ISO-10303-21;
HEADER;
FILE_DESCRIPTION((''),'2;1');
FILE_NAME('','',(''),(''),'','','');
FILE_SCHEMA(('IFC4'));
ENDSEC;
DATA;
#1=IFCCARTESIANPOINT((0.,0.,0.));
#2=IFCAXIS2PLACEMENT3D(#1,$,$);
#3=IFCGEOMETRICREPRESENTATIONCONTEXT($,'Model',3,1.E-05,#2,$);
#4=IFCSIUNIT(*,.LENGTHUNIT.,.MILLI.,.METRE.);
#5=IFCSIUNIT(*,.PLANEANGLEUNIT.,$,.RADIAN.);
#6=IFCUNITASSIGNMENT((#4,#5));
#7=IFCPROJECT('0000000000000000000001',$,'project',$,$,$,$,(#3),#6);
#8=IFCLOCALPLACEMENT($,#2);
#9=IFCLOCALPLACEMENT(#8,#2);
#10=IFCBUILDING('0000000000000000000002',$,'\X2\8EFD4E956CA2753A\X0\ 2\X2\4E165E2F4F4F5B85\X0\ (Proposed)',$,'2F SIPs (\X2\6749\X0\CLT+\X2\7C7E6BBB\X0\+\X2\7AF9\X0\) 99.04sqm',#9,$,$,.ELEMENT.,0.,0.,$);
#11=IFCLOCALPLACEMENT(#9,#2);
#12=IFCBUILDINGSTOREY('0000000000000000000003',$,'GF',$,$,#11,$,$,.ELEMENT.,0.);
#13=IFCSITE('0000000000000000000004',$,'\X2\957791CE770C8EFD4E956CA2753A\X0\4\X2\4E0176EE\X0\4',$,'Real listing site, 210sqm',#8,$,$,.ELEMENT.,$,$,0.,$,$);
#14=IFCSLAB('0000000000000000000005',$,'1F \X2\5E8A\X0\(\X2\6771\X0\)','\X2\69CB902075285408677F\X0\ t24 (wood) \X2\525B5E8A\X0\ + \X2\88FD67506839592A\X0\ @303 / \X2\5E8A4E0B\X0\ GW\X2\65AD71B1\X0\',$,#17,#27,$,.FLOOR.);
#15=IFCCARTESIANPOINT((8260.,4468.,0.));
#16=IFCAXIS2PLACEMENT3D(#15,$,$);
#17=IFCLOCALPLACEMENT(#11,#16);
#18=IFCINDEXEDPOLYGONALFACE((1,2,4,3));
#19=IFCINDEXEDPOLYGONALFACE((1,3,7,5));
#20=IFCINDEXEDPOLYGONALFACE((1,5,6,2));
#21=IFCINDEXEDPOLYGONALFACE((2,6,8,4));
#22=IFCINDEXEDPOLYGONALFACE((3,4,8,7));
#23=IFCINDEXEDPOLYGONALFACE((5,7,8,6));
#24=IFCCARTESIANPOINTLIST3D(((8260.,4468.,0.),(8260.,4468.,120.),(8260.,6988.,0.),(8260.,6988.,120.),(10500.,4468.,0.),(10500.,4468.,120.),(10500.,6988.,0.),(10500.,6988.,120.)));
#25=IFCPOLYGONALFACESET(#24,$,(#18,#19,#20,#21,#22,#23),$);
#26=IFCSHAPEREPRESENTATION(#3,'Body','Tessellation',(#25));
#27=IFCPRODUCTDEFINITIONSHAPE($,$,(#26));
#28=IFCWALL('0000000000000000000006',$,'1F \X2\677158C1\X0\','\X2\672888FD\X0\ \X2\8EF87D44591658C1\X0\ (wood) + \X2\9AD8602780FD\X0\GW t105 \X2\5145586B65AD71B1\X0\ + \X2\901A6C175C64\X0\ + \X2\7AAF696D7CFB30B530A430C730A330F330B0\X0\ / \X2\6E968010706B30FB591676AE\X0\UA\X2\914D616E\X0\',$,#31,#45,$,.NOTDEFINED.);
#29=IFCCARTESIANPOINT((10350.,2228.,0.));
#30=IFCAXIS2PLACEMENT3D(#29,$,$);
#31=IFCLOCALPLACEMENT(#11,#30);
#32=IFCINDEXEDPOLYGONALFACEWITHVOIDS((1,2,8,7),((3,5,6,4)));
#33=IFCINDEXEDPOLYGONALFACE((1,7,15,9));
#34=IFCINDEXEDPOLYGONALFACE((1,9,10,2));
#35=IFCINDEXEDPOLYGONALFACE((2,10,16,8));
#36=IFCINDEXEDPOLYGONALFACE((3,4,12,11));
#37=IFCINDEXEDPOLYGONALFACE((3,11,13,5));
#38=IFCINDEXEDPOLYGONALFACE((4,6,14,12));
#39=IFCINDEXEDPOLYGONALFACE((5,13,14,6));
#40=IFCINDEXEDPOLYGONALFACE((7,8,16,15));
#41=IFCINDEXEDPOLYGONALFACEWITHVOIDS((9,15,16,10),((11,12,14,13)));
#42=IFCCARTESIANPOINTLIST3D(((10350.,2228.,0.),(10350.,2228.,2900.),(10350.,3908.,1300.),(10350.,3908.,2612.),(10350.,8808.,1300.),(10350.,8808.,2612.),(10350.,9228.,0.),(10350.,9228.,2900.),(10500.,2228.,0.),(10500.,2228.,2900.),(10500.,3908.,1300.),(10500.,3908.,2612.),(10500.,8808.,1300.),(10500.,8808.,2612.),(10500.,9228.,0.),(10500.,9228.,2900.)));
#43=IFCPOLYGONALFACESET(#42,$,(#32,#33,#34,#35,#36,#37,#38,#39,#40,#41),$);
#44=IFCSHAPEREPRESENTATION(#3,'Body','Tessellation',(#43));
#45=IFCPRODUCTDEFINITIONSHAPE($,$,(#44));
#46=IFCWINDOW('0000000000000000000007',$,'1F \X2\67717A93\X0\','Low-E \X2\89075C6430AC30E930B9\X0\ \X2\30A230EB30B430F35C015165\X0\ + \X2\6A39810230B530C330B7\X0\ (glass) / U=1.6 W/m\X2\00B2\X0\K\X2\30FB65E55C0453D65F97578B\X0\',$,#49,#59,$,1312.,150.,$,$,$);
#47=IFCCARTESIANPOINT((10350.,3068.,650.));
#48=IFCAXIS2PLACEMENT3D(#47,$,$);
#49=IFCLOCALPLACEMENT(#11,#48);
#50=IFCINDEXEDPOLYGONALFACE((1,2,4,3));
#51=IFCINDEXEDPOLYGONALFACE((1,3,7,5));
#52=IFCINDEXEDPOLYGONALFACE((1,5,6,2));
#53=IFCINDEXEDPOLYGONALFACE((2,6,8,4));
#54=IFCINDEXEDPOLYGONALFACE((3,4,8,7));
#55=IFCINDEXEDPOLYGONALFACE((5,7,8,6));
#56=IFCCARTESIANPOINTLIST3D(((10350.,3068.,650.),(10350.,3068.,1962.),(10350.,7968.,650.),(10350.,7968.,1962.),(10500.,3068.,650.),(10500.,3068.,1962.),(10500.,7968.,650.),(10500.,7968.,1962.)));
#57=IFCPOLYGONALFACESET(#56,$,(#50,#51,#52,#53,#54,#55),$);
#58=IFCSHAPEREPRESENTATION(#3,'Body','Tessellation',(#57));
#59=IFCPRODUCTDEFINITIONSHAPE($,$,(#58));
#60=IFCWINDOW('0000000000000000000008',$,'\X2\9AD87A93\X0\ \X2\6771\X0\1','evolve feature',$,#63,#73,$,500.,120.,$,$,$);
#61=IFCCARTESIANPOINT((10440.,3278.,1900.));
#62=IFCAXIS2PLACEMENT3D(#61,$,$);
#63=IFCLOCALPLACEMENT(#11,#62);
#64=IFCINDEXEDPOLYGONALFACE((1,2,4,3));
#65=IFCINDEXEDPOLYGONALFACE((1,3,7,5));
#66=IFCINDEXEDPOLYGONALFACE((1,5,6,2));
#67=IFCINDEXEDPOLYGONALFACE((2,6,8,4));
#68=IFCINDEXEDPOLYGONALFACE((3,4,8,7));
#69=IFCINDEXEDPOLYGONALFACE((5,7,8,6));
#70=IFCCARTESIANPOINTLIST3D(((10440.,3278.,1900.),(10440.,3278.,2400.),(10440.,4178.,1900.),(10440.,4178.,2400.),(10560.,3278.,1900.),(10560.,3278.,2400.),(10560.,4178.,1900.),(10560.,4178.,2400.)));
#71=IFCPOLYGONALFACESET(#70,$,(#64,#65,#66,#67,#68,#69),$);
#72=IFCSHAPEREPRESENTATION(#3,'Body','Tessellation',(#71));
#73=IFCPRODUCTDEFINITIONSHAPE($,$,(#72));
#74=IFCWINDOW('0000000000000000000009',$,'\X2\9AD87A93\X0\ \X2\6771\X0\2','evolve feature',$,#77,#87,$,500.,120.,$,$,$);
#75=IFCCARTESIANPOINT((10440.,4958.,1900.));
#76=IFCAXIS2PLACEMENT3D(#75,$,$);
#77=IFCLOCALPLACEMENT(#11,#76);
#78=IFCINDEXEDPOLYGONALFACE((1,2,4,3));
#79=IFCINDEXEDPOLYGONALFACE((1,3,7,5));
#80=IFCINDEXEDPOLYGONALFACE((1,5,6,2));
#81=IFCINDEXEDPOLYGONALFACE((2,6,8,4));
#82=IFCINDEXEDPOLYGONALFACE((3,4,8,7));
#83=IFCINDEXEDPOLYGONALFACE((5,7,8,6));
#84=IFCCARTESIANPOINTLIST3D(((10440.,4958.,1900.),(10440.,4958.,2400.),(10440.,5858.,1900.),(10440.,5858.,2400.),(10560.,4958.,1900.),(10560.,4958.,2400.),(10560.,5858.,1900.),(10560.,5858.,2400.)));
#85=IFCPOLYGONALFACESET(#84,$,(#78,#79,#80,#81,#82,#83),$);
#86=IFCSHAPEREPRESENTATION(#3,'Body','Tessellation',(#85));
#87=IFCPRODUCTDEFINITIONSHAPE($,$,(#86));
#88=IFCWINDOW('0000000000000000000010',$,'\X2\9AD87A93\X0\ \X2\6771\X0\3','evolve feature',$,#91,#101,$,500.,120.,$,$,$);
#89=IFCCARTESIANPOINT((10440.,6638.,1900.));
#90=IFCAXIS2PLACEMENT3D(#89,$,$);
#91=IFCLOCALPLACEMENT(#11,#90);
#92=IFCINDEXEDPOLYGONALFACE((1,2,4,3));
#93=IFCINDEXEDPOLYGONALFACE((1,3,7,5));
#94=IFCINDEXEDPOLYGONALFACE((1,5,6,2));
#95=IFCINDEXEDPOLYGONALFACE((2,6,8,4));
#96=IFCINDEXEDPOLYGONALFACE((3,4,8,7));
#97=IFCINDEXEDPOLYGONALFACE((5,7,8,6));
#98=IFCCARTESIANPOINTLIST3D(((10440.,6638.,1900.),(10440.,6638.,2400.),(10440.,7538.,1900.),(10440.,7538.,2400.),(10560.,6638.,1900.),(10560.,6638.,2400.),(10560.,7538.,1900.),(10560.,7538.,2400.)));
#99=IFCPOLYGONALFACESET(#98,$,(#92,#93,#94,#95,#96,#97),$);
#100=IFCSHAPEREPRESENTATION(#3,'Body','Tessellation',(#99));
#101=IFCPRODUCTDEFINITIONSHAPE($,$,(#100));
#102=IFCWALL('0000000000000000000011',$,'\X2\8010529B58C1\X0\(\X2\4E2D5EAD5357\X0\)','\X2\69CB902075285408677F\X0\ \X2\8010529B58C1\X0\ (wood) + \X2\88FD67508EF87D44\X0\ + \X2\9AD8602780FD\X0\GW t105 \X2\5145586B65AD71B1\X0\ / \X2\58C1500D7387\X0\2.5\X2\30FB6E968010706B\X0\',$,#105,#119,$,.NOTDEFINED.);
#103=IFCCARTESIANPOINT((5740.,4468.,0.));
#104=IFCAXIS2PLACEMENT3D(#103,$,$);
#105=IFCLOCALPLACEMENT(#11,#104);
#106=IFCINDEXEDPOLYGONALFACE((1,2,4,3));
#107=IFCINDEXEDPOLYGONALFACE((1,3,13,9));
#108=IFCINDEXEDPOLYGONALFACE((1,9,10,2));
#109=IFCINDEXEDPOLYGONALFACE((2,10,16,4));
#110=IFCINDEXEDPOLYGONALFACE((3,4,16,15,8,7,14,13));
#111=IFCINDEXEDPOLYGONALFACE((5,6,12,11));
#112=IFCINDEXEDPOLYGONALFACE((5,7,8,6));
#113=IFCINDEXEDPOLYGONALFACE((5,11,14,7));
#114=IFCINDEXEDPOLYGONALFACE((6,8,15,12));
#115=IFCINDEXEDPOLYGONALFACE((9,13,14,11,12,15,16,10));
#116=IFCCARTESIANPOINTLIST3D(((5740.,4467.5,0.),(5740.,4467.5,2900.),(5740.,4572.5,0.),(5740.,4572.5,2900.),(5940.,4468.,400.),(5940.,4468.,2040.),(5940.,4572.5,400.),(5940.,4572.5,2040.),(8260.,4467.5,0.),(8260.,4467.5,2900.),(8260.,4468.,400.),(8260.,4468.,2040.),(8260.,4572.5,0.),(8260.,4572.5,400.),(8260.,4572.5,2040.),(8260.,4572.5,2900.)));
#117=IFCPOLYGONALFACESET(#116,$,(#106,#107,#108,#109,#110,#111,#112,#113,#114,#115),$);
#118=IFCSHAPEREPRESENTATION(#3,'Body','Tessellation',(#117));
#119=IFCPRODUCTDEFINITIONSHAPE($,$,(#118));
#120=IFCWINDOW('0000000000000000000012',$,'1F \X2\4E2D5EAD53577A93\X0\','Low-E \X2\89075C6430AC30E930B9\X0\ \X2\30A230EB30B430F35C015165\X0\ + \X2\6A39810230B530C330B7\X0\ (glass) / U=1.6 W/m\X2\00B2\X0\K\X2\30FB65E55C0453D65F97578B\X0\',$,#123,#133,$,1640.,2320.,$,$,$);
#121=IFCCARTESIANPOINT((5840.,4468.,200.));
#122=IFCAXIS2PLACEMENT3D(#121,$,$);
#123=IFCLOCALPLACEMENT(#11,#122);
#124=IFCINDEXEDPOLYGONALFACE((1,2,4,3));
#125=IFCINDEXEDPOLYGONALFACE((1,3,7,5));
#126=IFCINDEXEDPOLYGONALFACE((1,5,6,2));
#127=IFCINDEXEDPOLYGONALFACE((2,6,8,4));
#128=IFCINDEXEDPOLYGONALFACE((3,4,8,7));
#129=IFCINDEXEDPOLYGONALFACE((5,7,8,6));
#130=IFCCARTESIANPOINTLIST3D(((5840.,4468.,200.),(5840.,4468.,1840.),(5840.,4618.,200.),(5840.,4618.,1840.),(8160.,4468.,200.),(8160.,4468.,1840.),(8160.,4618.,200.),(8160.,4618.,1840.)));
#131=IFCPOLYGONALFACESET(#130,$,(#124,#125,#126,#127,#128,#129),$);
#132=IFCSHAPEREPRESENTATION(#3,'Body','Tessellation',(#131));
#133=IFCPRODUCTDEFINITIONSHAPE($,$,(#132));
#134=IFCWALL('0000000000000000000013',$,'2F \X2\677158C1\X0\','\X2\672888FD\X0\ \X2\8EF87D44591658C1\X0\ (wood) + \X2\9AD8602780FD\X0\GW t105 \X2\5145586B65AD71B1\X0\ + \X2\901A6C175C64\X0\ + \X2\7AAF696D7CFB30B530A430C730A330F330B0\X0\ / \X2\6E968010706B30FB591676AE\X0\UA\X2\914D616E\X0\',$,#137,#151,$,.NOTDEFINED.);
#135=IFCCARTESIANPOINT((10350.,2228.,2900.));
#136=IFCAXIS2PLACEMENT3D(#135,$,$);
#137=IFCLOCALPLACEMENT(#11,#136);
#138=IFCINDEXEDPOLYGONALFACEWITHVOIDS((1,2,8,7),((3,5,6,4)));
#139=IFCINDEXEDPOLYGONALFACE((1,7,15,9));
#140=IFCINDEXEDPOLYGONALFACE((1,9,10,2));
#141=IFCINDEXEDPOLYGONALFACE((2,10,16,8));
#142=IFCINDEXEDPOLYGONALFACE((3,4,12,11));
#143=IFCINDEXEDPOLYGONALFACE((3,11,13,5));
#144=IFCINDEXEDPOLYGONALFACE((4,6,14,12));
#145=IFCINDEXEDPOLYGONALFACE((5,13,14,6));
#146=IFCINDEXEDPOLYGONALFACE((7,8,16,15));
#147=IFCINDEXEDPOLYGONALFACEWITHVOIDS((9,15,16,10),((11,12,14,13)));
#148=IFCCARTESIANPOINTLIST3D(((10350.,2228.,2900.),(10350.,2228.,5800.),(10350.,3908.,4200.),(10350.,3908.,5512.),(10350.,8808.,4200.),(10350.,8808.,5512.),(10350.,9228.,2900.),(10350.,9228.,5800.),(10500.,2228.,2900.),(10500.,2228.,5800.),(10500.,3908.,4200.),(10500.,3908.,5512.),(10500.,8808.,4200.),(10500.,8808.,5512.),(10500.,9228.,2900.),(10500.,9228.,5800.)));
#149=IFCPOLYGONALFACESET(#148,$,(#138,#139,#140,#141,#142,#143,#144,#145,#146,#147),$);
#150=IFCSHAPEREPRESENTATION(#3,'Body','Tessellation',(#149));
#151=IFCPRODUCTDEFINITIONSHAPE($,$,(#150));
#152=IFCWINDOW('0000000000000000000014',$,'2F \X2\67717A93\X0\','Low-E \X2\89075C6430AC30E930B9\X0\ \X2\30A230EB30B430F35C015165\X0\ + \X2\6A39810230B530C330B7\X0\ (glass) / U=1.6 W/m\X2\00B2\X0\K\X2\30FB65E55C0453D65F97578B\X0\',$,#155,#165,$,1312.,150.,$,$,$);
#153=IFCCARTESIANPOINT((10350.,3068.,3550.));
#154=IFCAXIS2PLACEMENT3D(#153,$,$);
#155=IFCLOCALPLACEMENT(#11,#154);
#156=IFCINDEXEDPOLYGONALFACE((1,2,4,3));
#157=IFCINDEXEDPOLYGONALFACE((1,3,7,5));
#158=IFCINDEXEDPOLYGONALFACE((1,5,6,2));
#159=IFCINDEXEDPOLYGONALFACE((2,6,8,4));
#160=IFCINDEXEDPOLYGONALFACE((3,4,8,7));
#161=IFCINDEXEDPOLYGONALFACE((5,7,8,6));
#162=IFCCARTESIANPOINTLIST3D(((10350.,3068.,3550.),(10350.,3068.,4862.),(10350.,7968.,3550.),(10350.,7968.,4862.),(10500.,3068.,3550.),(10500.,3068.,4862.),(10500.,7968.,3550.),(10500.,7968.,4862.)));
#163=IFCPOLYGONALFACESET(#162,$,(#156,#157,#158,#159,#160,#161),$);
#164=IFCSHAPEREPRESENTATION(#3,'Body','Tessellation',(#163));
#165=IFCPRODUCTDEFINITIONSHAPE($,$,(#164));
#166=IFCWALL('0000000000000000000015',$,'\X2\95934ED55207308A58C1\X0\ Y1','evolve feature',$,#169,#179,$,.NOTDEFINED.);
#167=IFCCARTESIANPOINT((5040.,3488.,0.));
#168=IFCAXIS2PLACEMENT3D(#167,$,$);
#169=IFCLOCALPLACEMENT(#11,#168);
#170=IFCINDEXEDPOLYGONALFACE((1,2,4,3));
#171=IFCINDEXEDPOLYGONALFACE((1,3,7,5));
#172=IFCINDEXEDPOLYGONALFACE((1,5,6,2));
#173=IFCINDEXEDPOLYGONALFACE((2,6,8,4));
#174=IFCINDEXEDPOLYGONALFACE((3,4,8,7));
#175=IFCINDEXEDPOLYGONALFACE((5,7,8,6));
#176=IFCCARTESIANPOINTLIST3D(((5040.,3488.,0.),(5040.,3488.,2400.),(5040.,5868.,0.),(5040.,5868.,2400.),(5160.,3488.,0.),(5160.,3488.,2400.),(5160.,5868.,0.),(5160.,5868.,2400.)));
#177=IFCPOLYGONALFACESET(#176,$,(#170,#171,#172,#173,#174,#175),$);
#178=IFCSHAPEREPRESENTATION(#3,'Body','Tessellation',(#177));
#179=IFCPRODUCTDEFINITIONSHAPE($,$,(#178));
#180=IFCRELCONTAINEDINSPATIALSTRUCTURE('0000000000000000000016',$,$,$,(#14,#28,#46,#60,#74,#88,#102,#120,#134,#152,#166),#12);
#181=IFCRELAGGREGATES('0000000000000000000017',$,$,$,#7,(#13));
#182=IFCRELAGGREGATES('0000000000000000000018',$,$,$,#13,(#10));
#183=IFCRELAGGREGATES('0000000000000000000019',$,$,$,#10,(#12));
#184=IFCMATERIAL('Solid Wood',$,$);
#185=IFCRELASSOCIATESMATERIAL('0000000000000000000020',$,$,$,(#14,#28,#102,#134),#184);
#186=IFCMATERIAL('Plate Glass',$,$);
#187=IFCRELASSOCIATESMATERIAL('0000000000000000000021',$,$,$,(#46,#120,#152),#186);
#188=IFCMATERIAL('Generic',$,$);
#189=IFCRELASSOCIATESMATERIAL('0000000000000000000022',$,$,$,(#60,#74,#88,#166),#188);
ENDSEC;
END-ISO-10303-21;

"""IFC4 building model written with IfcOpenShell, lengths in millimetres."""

from ifc_helpers import new_model, si_unit, frame, frame_2d, origin, place, context, project, spatial, rectangle, extrude, material, element, fill, save


model = new_model("IFC4")

# Units and contexts
model_context = context("Model", 3, precision=1e-05, world=origin())
ifc_project = project(units=[si_unit("LENGTHUNIT", "METRE", prefix="MILLI"), si_unit("PLANEANGLEUNIT", "RADIAN")], contexts=[model_context])

# Site, building, storey
site_placement = place(None, origin())
site = spatial("IfcSite", under=ifc_project, at=site_placement, Name="長野県軽井沢町4丁目4", ObjectType="Real listing site, 210sqm", CompositionType="ELEMENT", RefElevation=0.0)
building_placement = place(site_placement, origin())
building = spatial("IfcBuilding", under=site, at=building_placement, Name="軽井沢町 2世帯住宅 (Proposed)", ObjectType="2F SIPs (杉CLT+籾殻+竹) 99.04sqm", CompositionType="ELEMENT", ElevationOfRefHeight=0.0, ElevationOfTerrain=0.0)
storey_placement = place(building_placement, origin())
storey = spatial("IfcBuildingStorey", under=building, at=storey_placement, Name="GF", CompositionType="ELEMENT", Elevation=0.0)

# Slab
ifc_material_1 = material(Name="Solid Wood")
slab_placement = place(storey_placement, frame((8260.0, 4468.0, 0.0)))
element("IfcSlab", 1, at=slab_placement, inside=storey, material=ifc_material_1, Name="1F 床(東)", Description="構造用合板 t24 (wood) 剛床 + 製材根太 @303 / 床下 GW断熱", PredefinedType="FLOOR", context=model_context, shape_type="SweptSolid", body=[
    extrude(rectangle(XDim=2240.0, YDim=2520.0, at=frame_2d((1120.0, 1260.0))), frame((8260.0, 4468.0, 0.0)), (0.0, 0.0, 1.0), 120.0),
])

# Wall, openings, windows
wall_1_placement = place(storey_placement, frame((10350.0, 2228.0, 0.0)))
wall_1 = element("IfcWall", 2, at=wall_1_placement, inside=storey, material=ifc_material_1, Name="1F 東壁", Description="木製 軸組外壁 (wood) + 高性能GW t105 充填断熱 + 通気層 + 窯業系サイディング / 準耐火・外皮UA配慮", PredefinedType="NOTDEFINED", context=model_context, shape_type="SweptSolid", body=[
    extrude(rectangle(XDim=150.0, YDim=7000.0, at=frame_2d((75.0, 3500.0))), frame((10350.0, 2228.0, 0.0)), (0.0, 0.0, 1.0), 2900.0),
])
opening_1_placement = place(storey_placement, frame((10350.0, 3068.0, 650.0)))
opening_1 = element("IfcOpeningElement", 3, at=opening_1_placement, cuts=wall_1, PredefinedType="NOTDEFINED", context=model_context, shape_type="SweptSolid", body=[
    extrude(rectangle(XDim=150.0, YDim=4900.0, at=frame_2d((75.0, 2450.0))), frame((10350.0, 3068.0, 650.0)), (0.0, 0.0, 1.0), 1312.0),
])
opening_2_placement = place(storey_placement, frame((10440.0, 3278.0, 1900.0)))
opening_2 = element("IfcOpeningElement", 4, at=opening_2_placement, cuts=wall_1, PredefinedType="NOTDEFINED", context=model_context, shape_type="SweptSolid", body=[
    extrude(rectangle(XDim=120.0, YDim=900.0, at=frame_2d((60.0, 450.0))), frame((10440.0, 3278.0, 1900.0)), (0.0, 0.0, 1.0), 500.0),
])
opening_3_placement = place(storey_placement, frame((10440.0, 4958.0, 1900.0)))
opening_3 = element("IfcOpeningElement", 5, at=opening_3_placement, cuts=wall_1, PredefinedType="NOTDEFINED", context=model_context, shape_type="SweptSolid", body=[
    extrude(rectangle(XDim=120.0, YDim=900.0, at=frame_2d((60.0, 450.0))), frame((10440.0, 4958.0, 1900.0)), (0.0, 0.0, 1.0), 500.0),
])
opening_4_placement = place(storey_placement, frame((10440.0, 6638.0, 1900.0)))
opening_4 = element("IfcOpeningElement", 6, at=opening_4_placement, cuts=wall_1, PredefinedType="NOTDEFINED", context=model_context, shape_type="SweptSolid", body=[
    extrude(rectangle(XDim=120.0, YDim=900.0, at=frame_2d((60.0, 450.0))), frame((10440.0, 6638.0, 1900.0)), (0.0, 0.0, 1.0), 500.0),
])
ifc_material_2 = material(Name="Plate Glass")
window_1_placement = place(storey_placement, frame((10350.0, 3068.0, 650.0)))
window_1 = element("IfcWindow", 7, at=window_1_placement, inside=storey, material=ifc_material_2, Name="1F 東窓", Description="Low-E 複層ガラス アルゴン封入 + 樹脂サッシ (glass) / U=1.6 W/m²K・日射取得型", OverallHeight=1312.0, OverallWidth=150.0, context=model_context, shape_type="SweptSolid", body=[
    extrude(rectangle(XDim=150.0, YDim=4900.0, at=frame_2d((75.0, 2450.0))), frame((10350.0, 3068.0, 650.0)), (0.0, 0.0, 1.0), 1312.0),
])
fill(opening_1, window_1)
ifc_material_3 = material(Name="Generic")
window_2_placement = place(storey_placement, frame((10440.0, 3278.0, 1900.0)))
window_2 = element("IfcWindow", 8, at=window_2_placement, inside=storey, material=ifc_material_3, Name="高窓 東1", Description="evolve feature", OverallHeight=500.0, OverallWidth=120.0, context=model_context, shape_type="SweptSolid", body=[
    extrude(rectangle(XDim=120.0, YDim=900.0, at=frame_2d((60.0, 450.0))), frame((10440.0, 3278.0, 1900.0)), (0.0, 0.0, 1.0), 500.0),
])
fill(opening_2, window_2)
window_3_placement = place(storey_placement, frame((10440.0, 4958.0, 1900.0)))
window_3 = element("IfcWindow", 9, at=window_3_placement, inside=storey, material=ifc_material_3, Name="高窓 東2", Description="evolve feature", OverallHeight=500.0, OverallWidth=120.0, context=model_context, shape_type="SweptSolid", body=[
    extrude(rectangle(XDim=120.0, YDim=900.0, at=frame_2d((60.0, 450.0))), frame((10440.0, 4958.0, 1900.0)), (0.0, 0.0, 1.0), 500.0),
])
fill(opening_3, window_3)
window_4_placement = place(storey_placement, frame((10440.0, 6638.0, 1900.0)))
window_4 = element("IfcWindow", 10, at=window_4_placement, inside=storey, material=ifc_material_3, Name="高窓 東3", Description="evolve feature", OverallHeight=500.0, OverallWidth=120.0, context=model_context, shape_type="SweptSolid", body=[
    extrude(rectangle(XDim=120.0, YDim=900.0, at=frame_2d((60.0, 450.0))), frame((10440.0, 6638.0, 1900.0)), (0.0, 0.0, 1.0), 500.0),
])
fill(opening_4, window_4)

# Wall, opening, window
wall_2_placement = place(storey_placement, frame((5740.0, 4468.0, 0.0)))
wall_2 = element("IfcWall", 11, at=wall_2_placement, inside=storey, material=ifc_material_1, Name="耐力壁(中庭南)", Description="構造用合板 耐力壁 (wood) + 製材軸組 + 高性能GW t105 充填断熱 / 壁倍率2.5・準耐火", PredefinedType="NOTDEFINED", context=model_context, shape_type="SweptSolid", body=[
    extrude(rectangle(XDim=2520.0, YDim=105.0, at=frame_2d((1260.0, 52.0))), frame((5740.0, 4468.0, 0.0)), (0.0, 0.0, 1.0), 2900.0),
])
opening_5_placement = place(storey_placement, frame((5840.0, 4468.0, 200.0)))
opening_5 = element("IfcOpeningElement", 12, at=opening_5_placement, cuts=wall_2, PredefinedType="NOTDEFINED", context=model_context, shape_type="SweptSolid", body=[
    extrude(rectangle(XDim=2320.0, YDim=150.0, at=frame_2d((1160.0, 75.0))), frame((5840.0, 4468.0, 200.0)), (0.0, 0.0, 1.0), 1640.0),
])
window_5_placement = place(storey_placement, frame((5840.0, 4468.0, 200.0)))
window_5 = element("IfcWindow", 13, at=window_5_placement, inside=storey, material=ifc_material_2, Name="1F 中庭南窓", Description="Low-E 複層ガラス アルゴン封入 + 樹脂サッシ (glass) / U=1.6 W/m²K・日射取得型", OverallHeight=1640.0, OverallWidth=2320.0, context=model_context, shape_type="SweptSolid", body=[
    extrude(rectangle(XDim=2320.0, YDim=150.0, at=frame_2d((1160.0, 75.0))), frame((5840.0, 4468.0, 200.0)), (0.0, 0.0, 1.0), 1640.0),
])
fill(opening_5, window_5)

# Wall, opening, window
wall_3_placement = place(storey_placement, frame((10350.0, 2228.0, 2900.0)))
wall_3 = element("IfcWall", 14, at=wall_3_placement, inside=storey, material=ifc_material_1, Name="2F 東壁", Description="木製 軸組外壁 (wood) + 高性能GW t105 充填断熱 + 通気層 + 窯業系サイディング / 準耐火・外皮UA配慮", PredefinedType="NOTDEFINED", context=model_context, shape_type="SweptSolid", body=[
    extrude(rectangle(XDim=150.0, YDim=7000.0, at=frame_2d((75.0, 3500.0))), frame((10350.0, 2228.0, 2900.0)), (0.0, 0.0, 1.0), 2900.0),
])
opening_6_placement = place(storey_placement, frame((10350.0, 3068.0, 3550.0)))
opening_6 = element("IfcOpeningElement", 15, at=opening_6_placement, cuts=wall_3, PredefinedType="NOTDEFINED", context=model_context, shape_type="SweptSolid", body=[
    extrude(rectangle(XDim=150.0, YDim=4900.0, at=frame_2d((75.0, 2450.0))), frame((10350.0, 3068.0, 3550.0)), (0.0, 0.0, 1.0), 1312.0),
])
window_6_placement = place(storey_placement, frame((10350.0, 3068.0, 3550.0)))
window_6 = element("IfcWindow", 16, at=window_6_placement, inside=storey, material=ifc_material_2, Name="2F 東窓", Description="Low-E 複層ガラス アルゴン封入 + 樹脂サッシ (glass) / U=1.6 W/m²K・日射取得型", OverallHeight=1312.0, OverallWidth=150.0, context=model_context, shape_type="SweptSolid", body=[
    extrude(rectangle(XDim=150.0, YDim=4900.0, at=frame_2d((75.0, 2450.0))), frame((10350.0, 3068.0, 3550.0)), (0.0, 0.0, 1.0), 1312.0),
])
fill(opening_6, window_6)

# Wall
wall_4_placement = place(storey_placement, frame((5040.0, 3488.0, 0.0)))
element("IfcWall", 17, at=wall_4_placement, inside=storey, material=ifc_material_3, Name="間仕切り壁 Y1", Description="evolve feature", PredefinedType="NOTDEFINED", context=model_context, shape_type="SweptSolid", body=[
    extrude(rectangle(XDim=120.0, YDim=2380.0, at=frame_2d((60.0, 1190.0))), frame((5040.0, 3488.0, 0.0)), (0.0, 0.0, 1.0), 2400.0),
])

save(model, "model.ifc")
